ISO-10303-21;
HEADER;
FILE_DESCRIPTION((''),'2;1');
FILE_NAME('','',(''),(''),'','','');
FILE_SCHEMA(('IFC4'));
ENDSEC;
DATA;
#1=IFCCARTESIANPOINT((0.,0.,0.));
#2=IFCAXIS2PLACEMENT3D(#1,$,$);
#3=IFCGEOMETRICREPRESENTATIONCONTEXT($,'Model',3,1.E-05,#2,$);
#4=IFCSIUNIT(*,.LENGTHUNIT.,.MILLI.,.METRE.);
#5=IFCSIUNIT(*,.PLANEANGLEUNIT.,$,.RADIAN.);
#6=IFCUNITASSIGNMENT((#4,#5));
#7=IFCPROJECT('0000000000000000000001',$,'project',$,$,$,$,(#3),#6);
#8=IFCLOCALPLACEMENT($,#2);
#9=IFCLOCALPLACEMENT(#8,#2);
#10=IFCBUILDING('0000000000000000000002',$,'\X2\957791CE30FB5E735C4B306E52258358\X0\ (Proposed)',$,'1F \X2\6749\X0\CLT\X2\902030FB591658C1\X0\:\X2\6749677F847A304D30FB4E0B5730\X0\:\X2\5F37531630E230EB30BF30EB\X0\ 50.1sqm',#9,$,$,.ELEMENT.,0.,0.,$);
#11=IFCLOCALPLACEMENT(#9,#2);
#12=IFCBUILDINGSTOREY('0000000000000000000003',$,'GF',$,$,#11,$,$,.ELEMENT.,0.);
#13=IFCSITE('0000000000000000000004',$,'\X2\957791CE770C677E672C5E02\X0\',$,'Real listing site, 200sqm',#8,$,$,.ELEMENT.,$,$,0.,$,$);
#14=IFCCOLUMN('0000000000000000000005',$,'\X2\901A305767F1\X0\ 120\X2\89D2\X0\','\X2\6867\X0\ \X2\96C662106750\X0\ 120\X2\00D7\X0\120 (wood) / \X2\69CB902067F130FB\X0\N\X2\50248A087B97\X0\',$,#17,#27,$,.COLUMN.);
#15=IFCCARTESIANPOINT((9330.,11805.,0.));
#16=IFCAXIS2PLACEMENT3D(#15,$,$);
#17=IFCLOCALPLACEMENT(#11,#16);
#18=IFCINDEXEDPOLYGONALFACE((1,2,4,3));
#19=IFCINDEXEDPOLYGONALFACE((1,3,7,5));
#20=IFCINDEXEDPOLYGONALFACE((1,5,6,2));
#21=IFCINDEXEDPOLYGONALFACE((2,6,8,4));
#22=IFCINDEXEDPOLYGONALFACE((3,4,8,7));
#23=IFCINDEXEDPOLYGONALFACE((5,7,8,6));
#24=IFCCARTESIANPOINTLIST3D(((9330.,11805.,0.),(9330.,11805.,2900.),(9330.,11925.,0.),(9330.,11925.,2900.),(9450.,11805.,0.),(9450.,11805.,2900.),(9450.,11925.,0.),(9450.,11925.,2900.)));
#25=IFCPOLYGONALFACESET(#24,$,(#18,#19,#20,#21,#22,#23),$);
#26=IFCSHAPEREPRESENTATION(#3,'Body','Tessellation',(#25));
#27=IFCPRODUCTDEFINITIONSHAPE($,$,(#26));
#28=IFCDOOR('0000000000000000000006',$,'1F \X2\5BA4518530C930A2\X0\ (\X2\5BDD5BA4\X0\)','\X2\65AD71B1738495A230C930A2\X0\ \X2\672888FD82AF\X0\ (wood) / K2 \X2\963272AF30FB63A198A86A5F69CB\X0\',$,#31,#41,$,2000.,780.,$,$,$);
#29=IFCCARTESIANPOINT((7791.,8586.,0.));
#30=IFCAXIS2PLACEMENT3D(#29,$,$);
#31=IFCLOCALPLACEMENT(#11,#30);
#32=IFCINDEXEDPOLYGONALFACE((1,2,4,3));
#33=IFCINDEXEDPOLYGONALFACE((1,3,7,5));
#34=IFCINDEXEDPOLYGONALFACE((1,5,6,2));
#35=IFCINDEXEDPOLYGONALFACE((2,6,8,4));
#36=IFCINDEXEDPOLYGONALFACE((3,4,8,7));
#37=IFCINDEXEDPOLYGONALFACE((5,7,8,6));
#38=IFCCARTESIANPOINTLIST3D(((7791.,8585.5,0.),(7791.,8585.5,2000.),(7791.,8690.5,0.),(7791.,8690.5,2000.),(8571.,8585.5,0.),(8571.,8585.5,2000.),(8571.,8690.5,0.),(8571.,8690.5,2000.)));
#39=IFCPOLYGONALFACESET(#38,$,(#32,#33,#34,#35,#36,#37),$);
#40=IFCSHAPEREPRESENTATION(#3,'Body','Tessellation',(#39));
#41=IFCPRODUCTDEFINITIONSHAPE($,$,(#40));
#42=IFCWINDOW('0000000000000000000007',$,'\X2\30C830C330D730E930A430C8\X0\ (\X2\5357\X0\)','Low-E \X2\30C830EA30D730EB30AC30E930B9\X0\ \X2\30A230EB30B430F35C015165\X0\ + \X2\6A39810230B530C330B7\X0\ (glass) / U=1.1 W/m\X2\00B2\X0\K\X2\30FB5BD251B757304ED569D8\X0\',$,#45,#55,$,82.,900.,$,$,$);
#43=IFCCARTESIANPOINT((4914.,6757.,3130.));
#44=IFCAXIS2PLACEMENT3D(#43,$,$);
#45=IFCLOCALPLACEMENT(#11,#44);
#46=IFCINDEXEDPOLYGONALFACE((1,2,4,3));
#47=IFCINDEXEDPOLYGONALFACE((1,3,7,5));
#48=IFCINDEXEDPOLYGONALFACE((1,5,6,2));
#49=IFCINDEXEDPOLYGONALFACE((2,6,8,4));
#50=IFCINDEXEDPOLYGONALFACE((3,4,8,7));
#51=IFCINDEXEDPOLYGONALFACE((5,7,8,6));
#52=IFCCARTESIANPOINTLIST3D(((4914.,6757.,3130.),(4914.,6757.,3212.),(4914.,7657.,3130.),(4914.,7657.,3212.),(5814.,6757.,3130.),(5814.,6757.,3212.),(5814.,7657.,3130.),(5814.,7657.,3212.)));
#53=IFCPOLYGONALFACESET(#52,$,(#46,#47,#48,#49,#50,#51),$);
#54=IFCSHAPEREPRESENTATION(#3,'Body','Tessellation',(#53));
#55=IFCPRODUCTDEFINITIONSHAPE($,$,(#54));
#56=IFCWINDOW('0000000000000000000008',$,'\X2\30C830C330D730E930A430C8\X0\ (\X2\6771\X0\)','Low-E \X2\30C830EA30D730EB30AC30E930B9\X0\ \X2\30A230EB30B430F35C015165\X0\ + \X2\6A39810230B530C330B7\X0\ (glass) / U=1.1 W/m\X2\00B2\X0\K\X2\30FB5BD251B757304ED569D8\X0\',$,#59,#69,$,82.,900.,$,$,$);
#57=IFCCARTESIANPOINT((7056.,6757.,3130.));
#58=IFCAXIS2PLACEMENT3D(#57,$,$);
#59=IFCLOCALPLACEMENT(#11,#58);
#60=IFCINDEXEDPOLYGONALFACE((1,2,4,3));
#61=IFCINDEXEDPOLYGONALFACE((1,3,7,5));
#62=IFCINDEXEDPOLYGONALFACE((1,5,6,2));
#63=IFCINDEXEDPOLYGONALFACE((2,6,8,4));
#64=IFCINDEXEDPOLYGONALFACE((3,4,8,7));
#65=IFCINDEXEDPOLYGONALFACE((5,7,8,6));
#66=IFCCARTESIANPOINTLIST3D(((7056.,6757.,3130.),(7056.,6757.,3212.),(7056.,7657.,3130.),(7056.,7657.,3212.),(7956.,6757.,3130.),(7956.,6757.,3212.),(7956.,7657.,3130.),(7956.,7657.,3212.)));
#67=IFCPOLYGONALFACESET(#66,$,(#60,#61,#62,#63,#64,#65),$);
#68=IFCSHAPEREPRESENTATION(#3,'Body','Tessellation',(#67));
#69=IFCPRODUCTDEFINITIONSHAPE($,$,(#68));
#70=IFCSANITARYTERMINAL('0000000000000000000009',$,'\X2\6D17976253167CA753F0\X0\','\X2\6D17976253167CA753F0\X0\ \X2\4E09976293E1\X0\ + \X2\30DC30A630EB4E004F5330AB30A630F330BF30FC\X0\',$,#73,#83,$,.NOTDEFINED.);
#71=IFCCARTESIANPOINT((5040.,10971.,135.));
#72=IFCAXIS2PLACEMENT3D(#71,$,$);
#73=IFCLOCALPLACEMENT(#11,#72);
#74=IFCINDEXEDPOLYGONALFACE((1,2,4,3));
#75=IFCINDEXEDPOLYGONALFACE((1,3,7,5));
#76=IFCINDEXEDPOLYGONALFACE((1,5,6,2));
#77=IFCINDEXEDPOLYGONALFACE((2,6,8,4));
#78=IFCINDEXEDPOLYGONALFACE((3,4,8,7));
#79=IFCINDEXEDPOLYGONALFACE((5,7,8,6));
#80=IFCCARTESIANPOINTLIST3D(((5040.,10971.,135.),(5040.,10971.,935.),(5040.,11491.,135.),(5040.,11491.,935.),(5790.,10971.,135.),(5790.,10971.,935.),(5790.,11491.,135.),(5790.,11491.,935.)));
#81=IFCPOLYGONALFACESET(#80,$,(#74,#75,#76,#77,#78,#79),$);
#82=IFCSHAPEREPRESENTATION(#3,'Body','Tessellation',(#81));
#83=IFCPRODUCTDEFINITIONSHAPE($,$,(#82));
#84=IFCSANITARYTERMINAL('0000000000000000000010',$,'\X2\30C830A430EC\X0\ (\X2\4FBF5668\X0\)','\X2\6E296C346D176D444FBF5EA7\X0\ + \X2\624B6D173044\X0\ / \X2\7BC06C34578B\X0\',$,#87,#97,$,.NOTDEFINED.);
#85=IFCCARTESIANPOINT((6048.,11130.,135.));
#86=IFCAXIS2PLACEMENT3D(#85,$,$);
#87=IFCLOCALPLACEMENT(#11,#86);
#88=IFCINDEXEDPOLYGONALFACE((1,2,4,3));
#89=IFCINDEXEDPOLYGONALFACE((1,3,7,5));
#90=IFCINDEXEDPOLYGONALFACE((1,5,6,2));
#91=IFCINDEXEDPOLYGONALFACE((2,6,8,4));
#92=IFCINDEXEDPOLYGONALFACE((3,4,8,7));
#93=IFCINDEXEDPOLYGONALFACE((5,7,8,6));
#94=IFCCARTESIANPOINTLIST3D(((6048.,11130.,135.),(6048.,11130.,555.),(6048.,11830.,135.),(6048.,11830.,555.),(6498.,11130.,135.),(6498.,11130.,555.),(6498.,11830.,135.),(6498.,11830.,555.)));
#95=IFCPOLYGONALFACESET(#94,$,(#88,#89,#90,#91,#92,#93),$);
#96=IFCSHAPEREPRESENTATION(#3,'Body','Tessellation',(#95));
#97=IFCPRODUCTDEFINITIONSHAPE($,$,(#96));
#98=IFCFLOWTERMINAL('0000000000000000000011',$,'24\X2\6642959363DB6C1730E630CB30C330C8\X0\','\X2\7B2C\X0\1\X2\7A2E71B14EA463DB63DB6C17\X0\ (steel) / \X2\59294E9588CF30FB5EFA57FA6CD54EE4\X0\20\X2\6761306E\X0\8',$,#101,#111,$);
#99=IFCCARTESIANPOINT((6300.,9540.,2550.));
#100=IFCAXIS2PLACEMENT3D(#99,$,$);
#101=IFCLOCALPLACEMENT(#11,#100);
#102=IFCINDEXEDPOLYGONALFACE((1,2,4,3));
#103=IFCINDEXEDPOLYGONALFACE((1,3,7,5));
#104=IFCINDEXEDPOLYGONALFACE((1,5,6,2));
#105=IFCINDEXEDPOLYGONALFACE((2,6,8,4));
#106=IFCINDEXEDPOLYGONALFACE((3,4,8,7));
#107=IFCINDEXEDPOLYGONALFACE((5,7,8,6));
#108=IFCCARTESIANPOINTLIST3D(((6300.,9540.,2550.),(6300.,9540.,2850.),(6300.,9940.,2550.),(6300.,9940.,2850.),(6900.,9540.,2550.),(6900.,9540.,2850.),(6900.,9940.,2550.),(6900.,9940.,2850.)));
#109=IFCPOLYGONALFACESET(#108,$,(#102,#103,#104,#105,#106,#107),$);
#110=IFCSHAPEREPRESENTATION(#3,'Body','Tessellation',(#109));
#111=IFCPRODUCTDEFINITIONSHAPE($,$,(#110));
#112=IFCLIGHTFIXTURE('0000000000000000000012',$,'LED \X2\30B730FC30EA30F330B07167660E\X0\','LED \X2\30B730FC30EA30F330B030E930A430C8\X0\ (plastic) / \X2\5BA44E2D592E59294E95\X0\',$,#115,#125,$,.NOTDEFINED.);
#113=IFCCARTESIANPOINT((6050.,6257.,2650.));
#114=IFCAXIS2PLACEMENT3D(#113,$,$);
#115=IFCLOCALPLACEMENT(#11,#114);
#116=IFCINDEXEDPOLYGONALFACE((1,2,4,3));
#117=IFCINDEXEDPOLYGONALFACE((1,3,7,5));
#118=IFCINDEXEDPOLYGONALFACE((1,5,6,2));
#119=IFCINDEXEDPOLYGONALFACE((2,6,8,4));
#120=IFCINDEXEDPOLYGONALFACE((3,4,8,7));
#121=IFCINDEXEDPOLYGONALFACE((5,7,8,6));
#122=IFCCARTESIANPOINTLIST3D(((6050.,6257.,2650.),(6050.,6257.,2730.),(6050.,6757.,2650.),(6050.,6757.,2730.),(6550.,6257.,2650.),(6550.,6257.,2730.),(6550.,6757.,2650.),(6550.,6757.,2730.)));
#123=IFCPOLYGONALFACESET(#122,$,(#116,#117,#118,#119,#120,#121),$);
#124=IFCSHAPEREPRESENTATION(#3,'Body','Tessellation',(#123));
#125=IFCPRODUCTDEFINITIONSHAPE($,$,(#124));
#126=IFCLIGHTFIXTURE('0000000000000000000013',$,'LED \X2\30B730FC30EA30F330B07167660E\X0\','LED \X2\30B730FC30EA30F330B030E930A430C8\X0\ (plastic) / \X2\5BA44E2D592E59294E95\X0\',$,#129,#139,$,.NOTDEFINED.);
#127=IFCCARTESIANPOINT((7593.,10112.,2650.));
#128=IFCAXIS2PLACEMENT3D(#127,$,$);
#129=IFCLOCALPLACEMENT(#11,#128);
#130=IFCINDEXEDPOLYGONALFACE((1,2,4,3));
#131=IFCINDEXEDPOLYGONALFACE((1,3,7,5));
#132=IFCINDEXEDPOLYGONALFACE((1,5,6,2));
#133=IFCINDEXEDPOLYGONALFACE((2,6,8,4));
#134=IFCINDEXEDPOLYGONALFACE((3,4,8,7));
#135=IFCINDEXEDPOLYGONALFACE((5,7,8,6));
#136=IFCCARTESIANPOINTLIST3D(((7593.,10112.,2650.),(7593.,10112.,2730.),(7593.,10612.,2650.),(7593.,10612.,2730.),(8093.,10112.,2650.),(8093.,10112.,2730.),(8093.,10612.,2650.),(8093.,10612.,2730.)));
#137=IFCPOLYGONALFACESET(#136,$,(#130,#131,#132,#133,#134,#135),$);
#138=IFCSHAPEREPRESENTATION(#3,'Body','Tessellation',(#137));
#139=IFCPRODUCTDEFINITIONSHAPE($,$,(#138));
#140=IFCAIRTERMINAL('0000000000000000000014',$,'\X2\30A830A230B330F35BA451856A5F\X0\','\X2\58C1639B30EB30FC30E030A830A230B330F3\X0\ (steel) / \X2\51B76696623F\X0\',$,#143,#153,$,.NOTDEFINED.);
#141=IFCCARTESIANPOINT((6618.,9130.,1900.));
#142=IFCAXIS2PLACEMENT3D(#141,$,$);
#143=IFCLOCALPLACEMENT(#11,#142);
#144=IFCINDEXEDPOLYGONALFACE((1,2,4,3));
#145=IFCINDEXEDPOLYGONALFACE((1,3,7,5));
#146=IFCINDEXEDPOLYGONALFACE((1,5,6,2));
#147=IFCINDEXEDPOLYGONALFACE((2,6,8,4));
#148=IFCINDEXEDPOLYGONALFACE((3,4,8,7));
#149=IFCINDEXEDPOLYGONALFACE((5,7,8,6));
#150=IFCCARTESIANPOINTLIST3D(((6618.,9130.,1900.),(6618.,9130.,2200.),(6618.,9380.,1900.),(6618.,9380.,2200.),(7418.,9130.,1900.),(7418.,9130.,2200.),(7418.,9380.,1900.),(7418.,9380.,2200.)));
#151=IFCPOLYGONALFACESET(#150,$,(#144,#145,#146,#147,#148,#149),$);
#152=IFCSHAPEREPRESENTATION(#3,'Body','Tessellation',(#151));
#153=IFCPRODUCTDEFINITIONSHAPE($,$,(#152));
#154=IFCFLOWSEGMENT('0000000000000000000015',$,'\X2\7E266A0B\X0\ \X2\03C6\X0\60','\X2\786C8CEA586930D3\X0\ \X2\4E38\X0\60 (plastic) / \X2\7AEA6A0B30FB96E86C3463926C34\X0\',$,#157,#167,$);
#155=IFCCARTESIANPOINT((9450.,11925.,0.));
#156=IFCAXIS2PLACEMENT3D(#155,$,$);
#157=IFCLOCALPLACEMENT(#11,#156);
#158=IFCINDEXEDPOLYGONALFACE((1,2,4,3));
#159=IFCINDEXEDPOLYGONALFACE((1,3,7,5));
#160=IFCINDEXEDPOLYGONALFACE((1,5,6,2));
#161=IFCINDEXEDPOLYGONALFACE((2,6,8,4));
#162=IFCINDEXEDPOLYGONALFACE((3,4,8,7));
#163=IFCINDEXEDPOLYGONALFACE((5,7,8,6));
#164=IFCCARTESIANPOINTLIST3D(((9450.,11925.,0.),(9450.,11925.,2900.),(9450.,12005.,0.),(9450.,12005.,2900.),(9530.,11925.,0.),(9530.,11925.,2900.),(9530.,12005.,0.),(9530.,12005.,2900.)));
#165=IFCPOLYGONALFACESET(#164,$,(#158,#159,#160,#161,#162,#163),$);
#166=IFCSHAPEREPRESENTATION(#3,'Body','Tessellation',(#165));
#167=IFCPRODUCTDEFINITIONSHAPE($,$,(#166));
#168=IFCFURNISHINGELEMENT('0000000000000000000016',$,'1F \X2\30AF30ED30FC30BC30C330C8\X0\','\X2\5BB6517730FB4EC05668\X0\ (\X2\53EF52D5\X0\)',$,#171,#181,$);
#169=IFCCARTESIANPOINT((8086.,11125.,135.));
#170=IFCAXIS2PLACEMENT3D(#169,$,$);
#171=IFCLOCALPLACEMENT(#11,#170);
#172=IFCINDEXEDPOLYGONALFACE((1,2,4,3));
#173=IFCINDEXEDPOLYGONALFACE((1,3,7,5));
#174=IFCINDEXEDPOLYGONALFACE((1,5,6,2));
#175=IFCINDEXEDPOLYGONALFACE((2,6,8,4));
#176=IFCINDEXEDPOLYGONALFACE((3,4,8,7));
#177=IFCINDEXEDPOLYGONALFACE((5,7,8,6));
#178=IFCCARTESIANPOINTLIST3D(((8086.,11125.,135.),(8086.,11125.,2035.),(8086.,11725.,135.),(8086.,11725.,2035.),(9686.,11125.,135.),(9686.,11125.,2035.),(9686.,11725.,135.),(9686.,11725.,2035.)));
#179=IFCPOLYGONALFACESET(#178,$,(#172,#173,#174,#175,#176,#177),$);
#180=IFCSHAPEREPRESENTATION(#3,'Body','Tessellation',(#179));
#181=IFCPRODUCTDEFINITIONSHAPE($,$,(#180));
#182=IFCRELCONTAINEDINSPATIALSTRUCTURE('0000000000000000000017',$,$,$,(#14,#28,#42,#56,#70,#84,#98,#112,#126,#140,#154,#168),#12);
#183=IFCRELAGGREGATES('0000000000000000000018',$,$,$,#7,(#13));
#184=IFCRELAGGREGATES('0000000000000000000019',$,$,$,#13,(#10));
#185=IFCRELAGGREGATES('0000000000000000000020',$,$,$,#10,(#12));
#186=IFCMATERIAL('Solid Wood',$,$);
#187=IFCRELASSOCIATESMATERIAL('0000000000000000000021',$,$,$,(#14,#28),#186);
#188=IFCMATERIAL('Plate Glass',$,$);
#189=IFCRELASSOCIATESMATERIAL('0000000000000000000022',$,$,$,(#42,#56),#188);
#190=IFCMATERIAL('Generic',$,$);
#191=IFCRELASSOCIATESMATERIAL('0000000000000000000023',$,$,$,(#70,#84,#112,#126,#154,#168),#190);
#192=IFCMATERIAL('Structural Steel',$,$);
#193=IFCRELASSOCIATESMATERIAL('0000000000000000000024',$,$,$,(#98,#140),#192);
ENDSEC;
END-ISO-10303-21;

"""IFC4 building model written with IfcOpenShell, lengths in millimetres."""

from ifc_helpers import new_model, si_unit, frame, frame_2d, origin, place, context, project, spatial, rectangle, extrude, material, element, save


model = new_model("IFC4")

# Units and contexts
model_context = context("Model", 3, precision=1e-05, world=origin())
ifc_project = project(units=[si_unit("LENGTHUNIT", "METRE", prefix="MILLI"), si_unit("PLANEANGLEUNIT", "RADIAN")], contexts=[model_context])

# Site, building, storey
site_placement = place(None, origin())
site = spatial("IfcSite", under=ifc_project, at=site_placement, Name="長野県松本市", ObjectType="Real listing site, 200sqm", CompositionType="ELEMENT", RefElevation=0.0)
building_placement = place(site_placement, origin())
building = spatial("IfcBuilding", under=site, at=building_placement, Name="長野・平屋の別荘 (Proposed)", ObjectType="1F 杉CLT造・外壁:杉板葺き・下地:強化モルタル 50.1sqm", CompositionType="ELEMENT", ElevationOfRefHeight=0.0, ElevationOfTerrain=0.0)
storey_placement = place(building_placement, origin())
storey = spatial("IfcBuildingStorey", under=building, at=storey_placement, Name="GF", CompositionType="ELEMENT", Elevation=0.0)

# Column
ifc_material_1 = material(Name="Solid Wood")
column_1_placement = place(storey_placement, frame((9330.0, 11805.0, 0.0)))
element("IfcColumn", 1, at=column_1_placement, inside=storey, material=ifc_material_1, Name="通し柱 120角", Description="桧 集成材 120×120 (wood) / 構造柱・N値計算", PredefinedType="COLUMN", context=model_context, shape_type="SweptSolid", body=[
    extrude(rectangle(XDim=120.0, YDim=120.0, at=frame_2d((60.0, 60.0))), frame((9330.0, 11805.0, 0.0)), (0.0, 0.0, 1.0), 2900.0),
])

# Door
door_placement = place(storey_placement, frame((7791.0, 8586.0, 0.0)))
element("IfcDoor", 2, at=door_placement, inside=storey, material=ifc_material_1, Name="1F 室内ドア (寝室)", Description="断熱玄関ドア 木製芯 (wood) / K2 防犯・採風機構", OverallHeight=2000.0, OverallWidth=780.0, context=model_context, shape_type="SweptSolid", body=[
    extrude(rectangle(XDim=780.0, YDim=105.0, at=frame_2d((390.0, 52.0))), frame((7791.0, 8586.0, 0.0)), (0.0, 0.0, 1.0), 2000.0),
])

# Windows
ifc_material_2 = material(Name="Plate Glass")
window_1_placement = place(storey_placement, frame((4914.0, 6757.0, 3130.0)))
element("IfcWindow", 3, at=window_1_placement, inside=storey, material=ifc_material_2, Name="トップライト (南)", Description="Low-E トリプルガラス アルゴン封入 + 樹脂サッシ (glass) / U=1.1 W/m²K・寒冷地仕様", OverallHeight=82.0, OverallWidth=900.0, context=model_context, shape_type="SweptSolid", body=[
    extrude(rectangle(XDim=900.0, YDim=900.0, at=frame_2d((450.0, 450.0))), frame((4914.0, 6757.0, 3130.0)), (0.0, 0.0, 1.0), 82.0),
])
window_2_placement = place(storey_placement, frame((7056.0, 6757.0, 3130.0)))
element("IfcWindow", 4, at=window_2_placement, inside=storey, material=ifc_material_2, Name="トップライト (東)", Description="Low-E トリプルガラス アルゴン封入 + 樹脂サッシ (glass) / U=1.1 W/m²K・寒冷地仕様", OverallHeight=82.0, OverallWidth=900.0, context=model_context, shape_type="SweptSolid", body=[
    extrude(rectangle(XDim=900.0, YDim=900.0, at=frame_2d((450.0, 450.0))), frame((7056.0, 6757.0, 3130.0)), (0.0, 0.0, 1.0), 82.0),
])

# Sanitary terminals
ifc_material_3 = material(Name="Generic")
sanitary_terminal_1_placement = place(storey_placement, frame((5040.0, 10971.0, 135.0)))
element("IfcSanitaryTerminal", 5, at=sanitary_terminal_1_placement, inside=storey, material=ifc_material_3, Name="洗面化粧台", Description="洗面化粧台 三面鏡 + ボウル一体カウンター", PredefinedType="NOTDEFINED", context=model_context, shape_type="SweptSolid", body=[
    extrude(rectangle(XDim=750.0, YDim=520.0, at=frame_2d((375.0, 260.0))), frame((5040.0, 10971.0, 135.0)), (0.0, 0.0, 1.0), 800.0),
])
sanitary_terminal_2_placement = place(storey_placement, frame((6048.0, 11130.0, 135.0)))
element("IfcSanitaryTerminal", 6, at=sanitary_terminal_2_placement, inside=storey, material=ifc_material_3, Name="トイレ (便器)", Description="温水洗浄便座 + 手洗い / 節水型", PredefinedType="NOTDEFINED", context=model_context, shape_type="SweptSolid", body=[
    extrude(rectangle(XDim=450.0, YDim=700.0, at=frame_2d((225.0, 350.0))), frame((6048.0, 11130.0, 135.0)), (0.0, 0.0, 1.0), 420.0),
])

# Flow terminal
ifc_material_4 = material(Name="Structural Steel")
flow_terminal_placement = place(storey_placement, frame((6300.0, 9540.0, 2550.0)))
element("IfcFlowTerminal", 7, at=flow_terminal_placement, inside=storey, material=ifc_material_4, Name="24時間換気ユニット", Description="第1種熱交換換気 (steel) / 天井裏・建基法令20条の8", context=model_context, shape_type="SweptSolid", body=[
    extrude(rectangle(XDim=600.0, YDim=400.0, at=frame_2d((300.0, 200.0))), frame((6300.0, 9540.0, 2550.0)), (0.0, 0.0, 1.0), 300.0),
])

# Light fixtures
light_fixture_1_placement = place(storey_placement, frame((6050.0, 6257.0, 2650.0)))
element("IfcLightFixture", 8, at=light_fixture_1_placement, inside=storey, material=ifc_material_3, Name="LED シーリング照明", Description="LED シーリングライト (plastic) / 室中央天井", PredefinedType="NOTDEFINED", context=model_context, shape_type="SweptSolid", body=[
    extrude(rectangle(XDim=500.0, YDim=500.0, at=frame_2d((250.0, 250.0))), frame((6050.0, 6257.0, 2650.0)), (0.0, 0.0, 1.0), 80.0),
])
light_fixture_2_placement = place(storey_placement, frame((7593.0, 10112.0, 2650.0)))
element("IfcLightFixture", 9, at=light_fixture_2_placement, inside=storey, material=ifc_material_3, Name="LED シーリング照明", Description="LED シーリングライト (plastic) / 室中央天井", PredefinedType="NOTDEFINED", context=model_context, shape_type="SweptSolid", body=[
    extrude(rectangle(XDim=500.0, YDim=500.0, at=frame_2d((250.0, 250.0))), frame((7593.0, 10112.0, 2650.0)), (0.0, 0.0, 1.0), 80.0),
])

# Air terminal
air_terminal_placement = place(storey_placement, frame((6618.0, 9130.0, 1900.0)))
element("IfcAirTerminal", 10, at=air_terminal_placement, inside=storey, material=ifc_material_4, Name="エアコン室内機", Description="壁掛ルームエアコン (steel) / 冷暖房", PredefinedType="NOTDEFINED", context=model_context, shape_type="SweptSolid", body=[
    extrude(rectangle(XDim=800.0, YDim=250.0, at=frame_2d((400.0, 125.0))), frame((6618.0, 9130.0, 1900.0)), (0.0, 0.0, 1.0), 300.0),
])

# Flow segment
flow_segment_placement = place(storey_placement, frame((9450.0, 11925.0, 0.0)))
element("IfcFlowSegment", 11, at=flow_segment_placement, inside=storey, material=ifc_material_3, Name="縦樋 φ60", Description="硬質塩ビ 丸60 (plastic) / 竪樋・雨水排水", context=model_context, shape_type="SweptSolid", body=[
    extrude(rectangle(XDim=80.0, YDim=80.0, at=frame_2d((40.0, 40.0))), frame((9450.0, 11925.0, 0.0)), (0.0, 0.0, 1.0), 2900.0),
])

# Furnishing element
furnishing_placement = place(storey_placement, frame((8086.0, 11125.0, 135.0)))
element("IfcFurnishingElement", 12, at=furnishing_placement, inside=storey, material=ifc_material_3, Name="1F クローゼット", Description="家具・什器 (可動)", context=model_context, shape_type="SweptSolid", body=[
    extrude(rectangle(XDim=1600.0, YDim=600.0, at=frame_2d((800.0, 300.0))), frame((8086.0, 11125.0, 135.0)), (0.0, 0.0, 1.0), 1900.0),
])

save(model, "model.ifc")
